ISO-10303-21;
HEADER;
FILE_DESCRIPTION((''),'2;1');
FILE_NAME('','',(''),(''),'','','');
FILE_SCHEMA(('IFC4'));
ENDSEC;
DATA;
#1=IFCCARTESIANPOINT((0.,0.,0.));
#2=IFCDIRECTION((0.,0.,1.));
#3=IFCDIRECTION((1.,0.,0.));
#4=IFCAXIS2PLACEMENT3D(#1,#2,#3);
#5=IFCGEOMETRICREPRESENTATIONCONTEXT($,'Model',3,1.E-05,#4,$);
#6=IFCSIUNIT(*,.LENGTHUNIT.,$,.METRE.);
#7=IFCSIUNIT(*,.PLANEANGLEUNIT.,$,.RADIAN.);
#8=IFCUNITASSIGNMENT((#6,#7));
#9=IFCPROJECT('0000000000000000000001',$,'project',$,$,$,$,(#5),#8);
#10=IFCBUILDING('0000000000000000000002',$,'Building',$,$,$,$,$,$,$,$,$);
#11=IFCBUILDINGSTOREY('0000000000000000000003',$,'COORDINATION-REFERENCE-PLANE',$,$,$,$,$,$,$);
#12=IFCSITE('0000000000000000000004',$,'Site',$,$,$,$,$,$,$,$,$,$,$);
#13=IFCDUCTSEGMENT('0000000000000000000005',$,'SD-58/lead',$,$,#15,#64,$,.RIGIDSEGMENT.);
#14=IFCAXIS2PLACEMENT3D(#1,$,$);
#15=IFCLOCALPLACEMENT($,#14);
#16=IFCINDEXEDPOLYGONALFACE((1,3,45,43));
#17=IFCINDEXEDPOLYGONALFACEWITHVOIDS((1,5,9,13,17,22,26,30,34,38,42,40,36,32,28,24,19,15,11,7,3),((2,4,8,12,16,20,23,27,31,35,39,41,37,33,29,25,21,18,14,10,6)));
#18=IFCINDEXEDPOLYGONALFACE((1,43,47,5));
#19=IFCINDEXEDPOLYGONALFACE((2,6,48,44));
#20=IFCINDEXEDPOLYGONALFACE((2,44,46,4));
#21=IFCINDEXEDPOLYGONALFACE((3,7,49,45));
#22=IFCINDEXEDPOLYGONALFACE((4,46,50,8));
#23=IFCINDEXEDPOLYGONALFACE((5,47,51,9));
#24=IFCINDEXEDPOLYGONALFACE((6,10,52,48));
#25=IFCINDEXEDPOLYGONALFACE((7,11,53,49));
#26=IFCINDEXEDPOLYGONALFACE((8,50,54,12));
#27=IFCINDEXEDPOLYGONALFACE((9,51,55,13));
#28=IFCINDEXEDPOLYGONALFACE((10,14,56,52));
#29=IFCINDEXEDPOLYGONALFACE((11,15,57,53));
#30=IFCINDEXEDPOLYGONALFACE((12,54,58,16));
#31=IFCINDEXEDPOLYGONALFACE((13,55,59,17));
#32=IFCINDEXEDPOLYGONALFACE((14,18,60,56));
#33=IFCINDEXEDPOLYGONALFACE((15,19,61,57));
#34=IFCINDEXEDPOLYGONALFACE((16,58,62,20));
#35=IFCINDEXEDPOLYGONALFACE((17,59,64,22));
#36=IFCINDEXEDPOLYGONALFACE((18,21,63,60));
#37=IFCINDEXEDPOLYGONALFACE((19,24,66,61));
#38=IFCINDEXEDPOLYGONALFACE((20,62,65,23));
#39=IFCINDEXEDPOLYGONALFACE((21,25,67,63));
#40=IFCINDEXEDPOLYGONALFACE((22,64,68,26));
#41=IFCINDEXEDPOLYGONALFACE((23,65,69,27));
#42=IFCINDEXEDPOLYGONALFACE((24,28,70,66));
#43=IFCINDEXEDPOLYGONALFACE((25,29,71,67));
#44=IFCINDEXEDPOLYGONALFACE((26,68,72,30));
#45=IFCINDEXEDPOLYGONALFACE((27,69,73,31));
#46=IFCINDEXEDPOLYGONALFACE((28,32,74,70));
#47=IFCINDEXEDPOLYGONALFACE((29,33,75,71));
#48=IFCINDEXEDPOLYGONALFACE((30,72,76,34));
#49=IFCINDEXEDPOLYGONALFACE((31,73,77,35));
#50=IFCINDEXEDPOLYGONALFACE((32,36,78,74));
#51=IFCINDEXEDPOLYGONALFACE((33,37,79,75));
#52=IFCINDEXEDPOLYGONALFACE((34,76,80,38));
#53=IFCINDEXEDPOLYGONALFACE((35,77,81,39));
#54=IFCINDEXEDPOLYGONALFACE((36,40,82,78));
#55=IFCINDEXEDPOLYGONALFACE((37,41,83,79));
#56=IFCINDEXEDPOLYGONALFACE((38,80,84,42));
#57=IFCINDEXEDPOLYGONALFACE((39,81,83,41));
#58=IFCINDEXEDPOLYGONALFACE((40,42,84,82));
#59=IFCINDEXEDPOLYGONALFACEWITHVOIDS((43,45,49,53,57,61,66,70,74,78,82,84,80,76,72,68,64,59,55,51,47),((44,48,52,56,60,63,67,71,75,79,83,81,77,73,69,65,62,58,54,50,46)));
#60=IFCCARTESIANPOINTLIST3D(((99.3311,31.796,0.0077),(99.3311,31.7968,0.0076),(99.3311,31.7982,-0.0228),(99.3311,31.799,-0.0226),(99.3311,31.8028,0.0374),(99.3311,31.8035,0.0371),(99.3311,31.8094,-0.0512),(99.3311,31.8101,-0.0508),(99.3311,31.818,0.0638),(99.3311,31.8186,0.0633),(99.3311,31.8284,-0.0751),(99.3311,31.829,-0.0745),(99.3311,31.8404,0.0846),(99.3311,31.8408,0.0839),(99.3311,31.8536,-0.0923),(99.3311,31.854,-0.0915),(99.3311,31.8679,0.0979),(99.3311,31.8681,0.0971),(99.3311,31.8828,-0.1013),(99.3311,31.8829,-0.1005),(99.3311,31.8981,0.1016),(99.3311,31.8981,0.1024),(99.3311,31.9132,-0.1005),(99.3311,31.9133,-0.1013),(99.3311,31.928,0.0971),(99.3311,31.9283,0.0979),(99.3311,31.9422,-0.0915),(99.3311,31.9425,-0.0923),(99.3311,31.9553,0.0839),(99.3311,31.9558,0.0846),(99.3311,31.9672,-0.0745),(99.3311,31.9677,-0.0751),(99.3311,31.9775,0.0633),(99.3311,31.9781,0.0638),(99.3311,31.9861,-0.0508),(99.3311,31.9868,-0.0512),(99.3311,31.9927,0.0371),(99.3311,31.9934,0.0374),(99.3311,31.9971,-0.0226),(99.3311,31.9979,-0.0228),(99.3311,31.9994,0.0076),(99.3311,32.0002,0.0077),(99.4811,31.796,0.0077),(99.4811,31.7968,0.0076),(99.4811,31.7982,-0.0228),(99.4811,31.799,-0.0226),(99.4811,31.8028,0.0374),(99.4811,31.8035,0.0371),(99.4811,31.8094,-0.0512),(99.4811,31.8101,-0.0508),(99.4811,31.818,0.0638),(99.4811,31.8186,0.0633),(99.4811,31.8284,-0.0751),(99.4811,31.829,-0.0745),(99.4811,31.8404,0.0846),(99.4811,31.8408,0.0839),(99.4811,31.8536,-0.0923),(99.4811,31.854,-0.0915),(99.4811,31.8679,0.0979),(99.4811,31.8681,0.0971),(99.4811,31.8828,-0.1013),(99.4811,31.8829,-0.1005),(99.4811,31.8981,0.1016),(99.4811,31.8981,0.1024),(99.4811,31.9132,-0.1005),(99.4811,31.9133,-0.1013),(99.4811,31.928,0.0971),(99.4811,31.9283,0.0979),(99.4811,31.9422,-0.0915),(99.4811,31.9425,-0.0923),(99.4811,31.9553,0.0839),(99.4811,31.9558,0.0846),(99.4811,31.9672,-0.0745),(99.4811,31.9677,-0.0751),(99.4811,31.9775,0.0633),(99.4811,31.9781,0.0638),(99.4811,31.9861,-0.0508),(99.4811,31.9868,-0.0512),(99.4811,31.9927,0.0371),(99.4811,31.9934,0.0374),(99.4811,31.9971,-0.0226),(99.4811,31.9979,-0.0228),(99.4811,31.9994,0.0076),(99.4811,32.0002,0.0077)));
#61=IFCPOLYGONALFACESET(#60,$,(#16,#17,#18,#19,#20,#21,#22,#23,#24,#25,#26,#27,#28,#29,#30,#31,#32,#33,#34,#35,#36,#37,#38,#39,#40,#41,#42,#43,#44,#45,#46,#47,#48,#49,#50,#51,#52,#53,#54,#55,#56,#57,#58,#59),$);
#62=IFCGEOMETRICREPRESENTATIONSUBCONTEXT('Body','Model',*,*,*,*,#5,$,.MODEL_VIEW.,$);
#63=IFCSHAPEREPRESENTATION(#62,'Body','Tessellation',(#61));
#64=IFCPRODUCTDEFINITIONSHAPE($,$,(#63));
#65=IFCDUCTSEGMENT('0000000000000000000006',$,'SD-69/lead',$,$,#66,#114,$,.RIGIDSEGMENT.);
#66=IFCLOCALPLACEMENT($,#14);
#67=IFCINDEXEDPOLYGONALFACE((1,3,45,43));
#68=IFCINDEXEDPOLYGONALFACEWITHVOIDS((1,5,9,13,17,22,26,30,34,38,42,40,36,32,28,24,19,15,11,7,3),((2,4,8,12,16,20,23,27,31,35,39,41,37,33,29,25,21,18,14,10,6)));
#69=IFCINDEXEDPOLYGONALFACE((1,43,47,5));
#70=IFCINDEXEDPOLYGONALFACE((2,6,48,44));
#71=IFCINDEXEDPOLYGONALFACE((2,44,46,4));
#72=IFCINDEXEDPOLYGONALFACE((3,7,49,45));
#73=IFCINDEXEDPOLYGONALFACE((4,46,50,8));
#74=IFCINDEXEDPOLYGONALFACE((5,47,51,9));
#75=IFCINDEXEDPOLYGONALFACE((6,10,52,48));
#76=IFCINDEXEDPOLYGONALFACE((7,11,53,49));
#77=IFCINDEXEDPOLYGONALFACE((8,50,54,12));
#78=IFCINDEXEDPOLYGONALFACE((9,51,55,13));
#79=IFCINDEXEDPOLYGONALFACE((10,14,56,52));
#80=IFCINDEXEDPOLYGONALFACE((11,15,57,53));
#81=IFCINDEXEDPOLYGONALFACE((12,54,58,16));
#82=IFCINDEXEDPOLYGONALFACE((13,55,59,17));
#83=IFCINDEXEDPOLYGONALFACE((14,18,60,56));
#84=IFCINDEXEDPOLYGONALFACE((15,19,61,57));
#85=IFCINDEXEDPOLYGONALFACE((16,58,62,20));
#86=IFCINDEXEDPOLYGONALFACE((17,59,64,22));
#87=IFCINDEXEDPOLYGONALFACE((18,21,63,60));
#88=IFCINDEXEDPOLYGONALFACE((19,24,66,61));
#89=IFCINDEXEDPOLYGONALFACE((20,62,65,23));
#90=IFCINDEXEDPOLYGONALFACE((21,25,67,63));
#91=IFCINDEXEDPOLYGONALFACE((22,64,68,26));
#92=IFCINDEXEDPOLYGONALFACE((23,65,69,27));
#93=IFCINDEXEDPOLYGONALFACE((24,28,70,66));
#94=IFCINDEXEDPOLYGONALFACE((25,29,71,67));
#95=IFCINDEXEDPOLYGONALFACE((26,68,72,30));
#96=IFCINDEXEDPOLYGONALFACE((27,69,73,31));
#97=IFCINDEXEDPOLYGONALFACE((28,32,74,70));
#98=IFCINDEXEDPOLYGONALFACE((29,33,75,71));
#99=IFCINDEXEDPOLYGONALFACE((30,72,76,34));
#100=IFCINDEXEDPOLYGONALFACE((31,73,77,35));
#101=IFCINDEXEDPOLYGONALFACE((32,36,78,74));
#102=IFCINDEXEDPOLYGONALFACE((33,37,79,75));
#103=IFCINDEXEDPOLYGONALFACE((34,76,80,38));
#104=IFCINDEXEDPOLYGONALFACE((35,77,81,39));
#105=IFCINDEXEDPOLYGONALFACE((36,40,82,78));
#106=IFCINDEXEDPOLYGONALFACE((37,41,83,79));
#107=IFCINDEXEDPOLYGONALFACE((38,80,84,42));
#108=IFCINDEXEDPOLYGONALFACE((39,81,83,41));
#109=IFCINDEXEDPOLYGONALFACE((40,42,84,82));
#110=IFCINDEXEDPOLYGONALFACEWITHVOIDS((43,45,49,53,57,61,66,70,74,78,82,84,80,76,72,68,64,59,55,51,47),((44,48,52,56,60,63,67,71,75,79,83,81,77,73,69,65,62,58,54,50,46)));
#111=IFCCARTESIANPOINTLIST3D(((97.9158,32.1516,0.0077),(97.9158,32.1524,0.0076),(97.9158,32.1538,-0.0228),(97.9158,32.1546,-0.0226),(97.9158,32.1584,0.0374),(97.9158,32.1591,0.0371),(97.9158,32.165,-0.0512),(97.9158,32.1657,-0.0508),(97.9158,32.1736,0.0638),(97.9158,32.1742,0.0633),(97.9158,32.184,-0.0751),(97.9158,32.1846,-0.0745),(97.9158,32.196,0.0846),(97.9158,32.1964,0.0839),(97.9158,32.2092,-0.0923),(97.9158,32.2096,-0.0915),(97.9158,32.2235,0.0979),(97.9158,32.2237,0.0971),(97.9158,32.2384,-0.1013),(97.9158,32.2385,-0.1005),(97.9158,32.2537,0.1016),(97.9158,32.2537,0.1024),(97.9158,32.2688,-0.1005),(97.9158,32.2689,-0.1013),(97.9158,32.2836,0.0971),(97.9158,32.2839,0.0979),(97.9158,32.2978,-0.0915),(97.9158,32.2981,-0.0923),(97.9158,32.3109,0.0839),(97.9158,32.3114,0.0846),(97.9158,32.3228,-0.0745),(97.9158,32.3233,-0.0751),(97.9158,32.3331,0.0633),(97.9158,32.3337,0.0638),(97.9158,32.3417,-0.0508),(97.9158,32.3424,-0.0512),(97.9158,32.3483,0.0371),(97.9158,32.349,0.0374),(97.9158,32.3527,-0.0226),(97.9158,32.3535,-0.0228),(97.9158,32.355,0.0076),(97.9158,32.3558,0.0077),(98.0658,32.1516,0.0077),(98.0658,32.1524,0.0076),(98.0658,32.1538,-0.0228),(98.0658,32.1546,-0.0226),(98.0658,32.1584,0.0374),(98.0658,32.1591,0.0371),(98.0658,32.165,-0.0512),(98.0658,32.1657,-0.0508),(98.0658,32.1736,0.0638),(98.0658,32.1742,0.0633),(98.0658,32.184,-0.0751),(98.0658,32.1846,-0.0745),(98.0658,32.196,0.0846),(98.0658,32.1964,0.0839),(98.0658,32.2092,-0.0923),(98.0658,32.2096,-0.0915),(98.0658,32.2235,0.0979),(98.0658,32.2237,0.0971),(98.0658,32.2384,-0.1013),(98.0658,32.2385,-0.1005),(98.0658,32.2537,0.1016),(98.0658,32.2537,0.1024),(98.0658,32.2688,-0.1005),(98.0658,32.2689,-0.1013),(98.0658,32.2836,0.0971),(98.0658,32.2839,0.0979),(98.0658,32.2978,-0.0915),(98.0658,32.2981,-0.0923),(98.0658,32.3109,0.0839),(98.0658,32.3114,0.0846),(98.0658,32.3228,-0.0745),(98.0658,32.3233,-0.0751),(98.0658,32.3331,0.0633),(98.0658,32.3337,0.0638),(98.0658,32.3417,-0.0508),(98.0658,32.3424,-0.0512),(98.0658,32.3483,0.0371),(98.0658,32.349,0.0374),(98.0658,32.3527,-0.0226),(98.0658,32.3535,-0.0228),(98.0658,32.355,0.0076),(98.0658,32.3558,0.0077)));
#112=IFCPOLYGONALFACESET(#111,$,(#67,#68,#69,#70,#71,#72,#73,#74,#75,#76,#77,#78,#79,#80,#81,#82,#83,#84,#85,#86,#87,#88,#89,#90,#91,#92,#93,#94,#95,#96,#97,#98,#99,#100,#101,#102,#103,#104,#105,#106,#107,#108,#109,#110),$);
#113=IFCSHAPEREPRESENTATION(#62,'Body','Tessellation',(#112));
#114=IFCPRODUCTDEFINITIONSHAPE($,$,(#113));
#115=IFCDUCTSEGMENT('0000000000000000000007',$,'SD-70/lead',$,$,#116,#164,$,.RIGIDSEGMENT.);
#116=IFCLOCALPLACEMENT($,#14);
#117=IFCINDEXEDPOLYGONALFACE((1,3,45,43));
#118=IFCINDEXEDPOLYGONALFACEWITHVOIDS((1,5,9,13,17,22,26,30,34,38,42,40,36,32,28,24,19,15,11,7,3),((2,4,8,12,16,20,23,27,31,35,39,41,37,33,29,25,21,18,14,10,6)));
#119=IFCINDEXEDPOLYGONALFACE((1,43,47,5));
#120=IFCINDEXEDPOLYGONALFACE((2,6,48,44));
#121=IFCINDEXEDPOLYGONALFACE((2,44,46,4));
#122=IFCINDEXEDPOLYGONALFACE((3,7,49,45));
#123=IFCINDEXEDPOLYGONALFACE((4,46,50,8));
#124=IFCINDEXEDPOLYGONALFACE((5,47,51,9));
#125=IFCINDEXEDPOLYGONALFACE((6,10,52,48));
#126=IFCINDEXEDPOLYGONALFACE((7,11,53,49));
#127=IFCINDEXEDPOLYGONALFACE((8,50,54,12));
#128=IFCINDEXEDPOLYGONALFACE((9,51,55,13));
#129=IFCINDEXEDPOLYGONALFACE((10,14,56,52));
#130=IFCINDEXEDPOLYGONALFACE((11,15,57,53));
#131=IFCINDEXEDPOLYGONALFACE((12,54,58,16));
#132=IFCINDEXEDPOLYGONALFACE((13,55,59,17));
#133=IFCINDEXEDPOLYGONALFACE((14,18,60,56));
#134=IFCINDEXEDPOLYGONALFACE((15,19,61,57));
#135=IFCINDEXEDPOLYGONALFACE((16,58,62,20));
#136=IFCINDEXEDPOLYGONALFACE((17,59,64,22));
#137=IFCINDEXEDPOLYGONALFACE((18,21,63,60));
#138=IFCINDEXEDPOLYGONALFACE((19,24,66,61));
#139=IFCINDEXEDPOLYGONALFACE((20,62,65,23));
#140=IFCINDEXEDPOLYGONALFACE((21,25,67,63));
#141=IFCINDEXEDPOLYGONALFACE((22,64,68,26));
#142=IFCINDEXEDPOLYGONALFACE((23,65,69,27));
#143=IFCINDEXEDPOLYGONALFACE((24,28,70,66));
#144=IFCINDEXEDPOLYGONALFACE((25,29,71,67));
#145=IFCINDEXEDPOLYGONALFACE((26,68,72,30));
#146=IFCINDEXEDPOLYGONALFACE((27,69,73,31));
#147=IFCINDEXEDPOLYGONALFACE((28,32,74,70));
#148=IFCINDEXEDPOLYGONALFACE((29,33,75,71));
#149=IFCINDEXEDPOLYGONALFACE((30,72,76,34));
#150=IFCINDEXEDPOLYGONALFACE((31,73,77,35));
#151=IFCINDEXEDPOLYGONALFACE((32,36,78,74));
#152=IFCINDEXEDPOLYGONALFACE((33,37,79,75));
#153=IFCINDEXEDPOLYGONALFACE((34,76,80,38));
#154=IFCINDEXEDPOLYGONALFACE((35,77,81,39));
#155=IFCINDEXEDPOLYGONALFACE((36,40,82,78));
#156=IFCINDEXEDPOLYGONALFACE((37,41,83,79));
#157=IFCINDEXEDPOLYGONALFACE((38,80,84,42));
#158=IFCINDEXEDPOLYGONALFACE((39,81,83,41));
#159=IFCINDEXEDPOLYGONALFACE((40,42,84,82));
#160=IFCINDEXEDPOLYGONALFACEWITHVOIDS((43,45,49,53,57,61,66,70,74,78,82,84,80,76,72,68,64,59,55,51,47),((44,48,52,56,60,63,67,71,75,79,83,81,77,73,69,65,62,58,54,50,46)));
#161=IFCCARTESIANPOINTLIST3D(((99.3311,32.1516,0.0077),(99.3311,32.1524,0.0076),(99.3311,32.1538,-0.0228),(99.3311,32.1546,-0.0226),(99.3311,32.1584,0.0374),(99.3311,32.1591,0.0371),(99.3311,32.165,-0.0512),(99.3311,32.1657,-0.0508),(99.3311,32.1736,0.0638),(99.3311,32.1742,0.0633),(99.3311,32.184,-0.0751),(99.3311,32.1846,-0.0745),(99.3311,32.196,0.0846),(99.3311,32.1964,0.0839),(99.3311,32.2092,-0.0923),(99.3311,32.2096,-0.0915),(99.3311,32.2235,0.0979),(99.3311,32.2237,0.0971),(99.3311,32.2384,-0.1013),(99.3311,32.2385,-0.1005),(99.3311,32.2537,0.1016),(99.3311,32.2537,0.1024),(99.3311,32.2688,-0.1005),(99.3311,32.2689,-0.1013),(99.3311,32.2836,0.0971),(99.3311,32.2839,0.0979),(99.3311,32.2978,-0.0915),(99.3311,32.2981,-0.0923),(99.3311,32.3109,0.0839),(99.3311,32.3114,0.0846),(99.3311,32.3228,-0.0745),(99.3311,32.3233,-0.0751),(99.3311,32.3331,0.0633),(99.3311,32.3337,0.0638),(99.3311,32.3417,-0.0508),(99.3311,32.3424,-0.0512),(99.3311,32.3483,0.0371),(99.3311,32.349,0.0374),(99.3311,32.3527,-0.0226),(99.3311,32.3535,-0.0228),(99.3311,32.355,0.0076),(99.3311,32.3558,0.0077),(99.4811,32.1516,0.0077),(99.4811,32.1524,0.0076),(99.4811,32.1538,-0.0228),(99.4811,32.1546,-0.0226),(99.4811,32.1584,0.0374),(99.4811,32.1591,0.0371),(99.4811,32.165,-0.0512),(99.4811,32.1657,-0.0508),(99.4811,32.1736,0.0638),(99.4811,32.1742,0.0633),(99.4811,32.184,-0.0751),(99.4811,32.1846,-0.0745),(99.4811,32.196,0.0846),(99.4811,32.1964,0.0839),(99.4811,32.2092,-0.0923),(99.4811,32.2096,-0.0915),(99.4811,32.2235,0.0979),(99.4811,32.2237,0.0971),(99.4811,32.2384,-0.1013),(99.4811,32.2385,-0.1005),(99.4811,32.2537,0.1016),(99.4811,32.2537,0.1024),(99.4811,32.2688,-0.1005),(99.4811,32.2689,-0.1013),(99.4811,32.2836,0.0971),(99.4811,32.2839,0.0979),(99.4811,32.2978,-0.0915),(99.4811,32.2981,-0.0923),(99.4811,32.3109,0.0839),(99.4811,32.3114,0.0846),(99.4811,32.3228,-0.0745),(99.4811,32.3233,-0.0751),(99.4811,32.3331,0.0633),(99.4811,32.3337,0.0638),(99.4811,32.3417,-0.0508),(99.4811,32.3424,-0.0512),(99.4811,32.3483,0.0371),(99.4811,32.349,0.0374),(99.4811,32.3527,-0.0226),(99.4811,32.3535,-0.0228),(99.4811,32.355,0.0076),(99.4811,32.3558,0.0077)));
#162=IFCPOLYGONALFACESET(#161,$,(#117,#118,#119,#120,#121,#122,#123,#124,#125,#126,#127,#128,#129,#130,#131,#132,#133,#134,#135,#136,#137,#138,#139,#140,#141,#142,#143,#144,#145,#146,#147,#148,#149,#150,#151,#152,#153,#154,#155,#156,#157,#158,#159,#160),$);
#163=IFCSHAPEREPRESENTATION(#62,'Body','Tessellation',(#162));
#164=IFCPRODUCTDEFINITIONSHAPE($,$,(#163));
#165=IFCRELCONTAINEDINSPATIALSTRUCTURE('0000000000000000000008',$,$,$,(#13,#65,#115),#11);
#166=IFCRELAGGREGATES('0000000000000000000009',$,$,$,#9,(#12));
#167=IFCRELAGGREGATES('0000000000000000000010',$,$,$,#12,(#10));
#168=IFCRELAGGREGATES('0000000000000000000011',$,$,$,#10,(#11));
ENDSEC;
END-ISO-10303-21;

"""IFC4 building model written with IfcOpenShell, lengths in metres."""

from ifc_helpers import new_model, si_unit, frame, origin_with_axes, place, context, subcontext, project, spatial, hollow_circle, extrude, element, save


model = new_model("IFC4")

# Units and contexts
model_context = context("Model", 3, precision=1e-05, world=origin_with_axes())
body_context_1 = subcontext(model_context, "Body", "Model", "MODEL_VIEW")
ifc_project = project(units=[si_unit("LENGTHUNIT", "METRE"), si_unit("PLANEANGLEUNIT", "RADIAN")], contexts=[model_context])

# Site, building, storey
site = spatial("IfcSite", under=ifc_project, Name="Site")
building = spatial("IfcBuilding", under=site, Name="Building")
storey = spatial("IfcBuildingStorey", under=building, Name="COORDINATION-REFERENCE-PLANE")

# Duct segment
duct_segment_1_placement = place(None, frame((99.3311, 31.8981, 0.0), z_axis=(1.0, 0.0, 0.0), x_axis=(0.0, 0.0, 1.0)))
element("IfcDuctSegment", 1, at=duct_segment_1_placement, inside=storey, Name="SD-58/lead", PredefinedType="RIGIDSEGMENT", context=body_context_1, shape_type="SweptSolid", body=[
    extrude(hollow_circle(Radius=0.1024, WallThickness=0.0008), origin_with_axes(), (0.0, 0.0, 1.0), 0.15),
])

# Duct segments
for number, where, z_axis, x_axis, name in (
    (2, (98.0658, 32.2537, 0.0), (-1.0, 0.0, 0.0), (0.0, 0.0, 1.0), "SD-69/lead"),
    (3, (99.3311, 32.2537, 0.0), (1.0, 0.0, 0.0), (0.0, 0.0, 1.0), "SD-70/lead"),
):
    element("IfcDuctSegment", number, at=place(None, frame(where, z_axis=z_axis, x_axis=x_axis)), inside=storey, Name=name, PredefinedType="RIGIDSEGMENT", context=body_context_1, shape_type="SweptSolid", body=[
        extrude(hollow_circle(Radius=0.1024, WallThickness=0.0008), origin_with_axes(), (0.0, 0.0, 1.0), 0.15),
    ])

save(model, "model.ifc")
